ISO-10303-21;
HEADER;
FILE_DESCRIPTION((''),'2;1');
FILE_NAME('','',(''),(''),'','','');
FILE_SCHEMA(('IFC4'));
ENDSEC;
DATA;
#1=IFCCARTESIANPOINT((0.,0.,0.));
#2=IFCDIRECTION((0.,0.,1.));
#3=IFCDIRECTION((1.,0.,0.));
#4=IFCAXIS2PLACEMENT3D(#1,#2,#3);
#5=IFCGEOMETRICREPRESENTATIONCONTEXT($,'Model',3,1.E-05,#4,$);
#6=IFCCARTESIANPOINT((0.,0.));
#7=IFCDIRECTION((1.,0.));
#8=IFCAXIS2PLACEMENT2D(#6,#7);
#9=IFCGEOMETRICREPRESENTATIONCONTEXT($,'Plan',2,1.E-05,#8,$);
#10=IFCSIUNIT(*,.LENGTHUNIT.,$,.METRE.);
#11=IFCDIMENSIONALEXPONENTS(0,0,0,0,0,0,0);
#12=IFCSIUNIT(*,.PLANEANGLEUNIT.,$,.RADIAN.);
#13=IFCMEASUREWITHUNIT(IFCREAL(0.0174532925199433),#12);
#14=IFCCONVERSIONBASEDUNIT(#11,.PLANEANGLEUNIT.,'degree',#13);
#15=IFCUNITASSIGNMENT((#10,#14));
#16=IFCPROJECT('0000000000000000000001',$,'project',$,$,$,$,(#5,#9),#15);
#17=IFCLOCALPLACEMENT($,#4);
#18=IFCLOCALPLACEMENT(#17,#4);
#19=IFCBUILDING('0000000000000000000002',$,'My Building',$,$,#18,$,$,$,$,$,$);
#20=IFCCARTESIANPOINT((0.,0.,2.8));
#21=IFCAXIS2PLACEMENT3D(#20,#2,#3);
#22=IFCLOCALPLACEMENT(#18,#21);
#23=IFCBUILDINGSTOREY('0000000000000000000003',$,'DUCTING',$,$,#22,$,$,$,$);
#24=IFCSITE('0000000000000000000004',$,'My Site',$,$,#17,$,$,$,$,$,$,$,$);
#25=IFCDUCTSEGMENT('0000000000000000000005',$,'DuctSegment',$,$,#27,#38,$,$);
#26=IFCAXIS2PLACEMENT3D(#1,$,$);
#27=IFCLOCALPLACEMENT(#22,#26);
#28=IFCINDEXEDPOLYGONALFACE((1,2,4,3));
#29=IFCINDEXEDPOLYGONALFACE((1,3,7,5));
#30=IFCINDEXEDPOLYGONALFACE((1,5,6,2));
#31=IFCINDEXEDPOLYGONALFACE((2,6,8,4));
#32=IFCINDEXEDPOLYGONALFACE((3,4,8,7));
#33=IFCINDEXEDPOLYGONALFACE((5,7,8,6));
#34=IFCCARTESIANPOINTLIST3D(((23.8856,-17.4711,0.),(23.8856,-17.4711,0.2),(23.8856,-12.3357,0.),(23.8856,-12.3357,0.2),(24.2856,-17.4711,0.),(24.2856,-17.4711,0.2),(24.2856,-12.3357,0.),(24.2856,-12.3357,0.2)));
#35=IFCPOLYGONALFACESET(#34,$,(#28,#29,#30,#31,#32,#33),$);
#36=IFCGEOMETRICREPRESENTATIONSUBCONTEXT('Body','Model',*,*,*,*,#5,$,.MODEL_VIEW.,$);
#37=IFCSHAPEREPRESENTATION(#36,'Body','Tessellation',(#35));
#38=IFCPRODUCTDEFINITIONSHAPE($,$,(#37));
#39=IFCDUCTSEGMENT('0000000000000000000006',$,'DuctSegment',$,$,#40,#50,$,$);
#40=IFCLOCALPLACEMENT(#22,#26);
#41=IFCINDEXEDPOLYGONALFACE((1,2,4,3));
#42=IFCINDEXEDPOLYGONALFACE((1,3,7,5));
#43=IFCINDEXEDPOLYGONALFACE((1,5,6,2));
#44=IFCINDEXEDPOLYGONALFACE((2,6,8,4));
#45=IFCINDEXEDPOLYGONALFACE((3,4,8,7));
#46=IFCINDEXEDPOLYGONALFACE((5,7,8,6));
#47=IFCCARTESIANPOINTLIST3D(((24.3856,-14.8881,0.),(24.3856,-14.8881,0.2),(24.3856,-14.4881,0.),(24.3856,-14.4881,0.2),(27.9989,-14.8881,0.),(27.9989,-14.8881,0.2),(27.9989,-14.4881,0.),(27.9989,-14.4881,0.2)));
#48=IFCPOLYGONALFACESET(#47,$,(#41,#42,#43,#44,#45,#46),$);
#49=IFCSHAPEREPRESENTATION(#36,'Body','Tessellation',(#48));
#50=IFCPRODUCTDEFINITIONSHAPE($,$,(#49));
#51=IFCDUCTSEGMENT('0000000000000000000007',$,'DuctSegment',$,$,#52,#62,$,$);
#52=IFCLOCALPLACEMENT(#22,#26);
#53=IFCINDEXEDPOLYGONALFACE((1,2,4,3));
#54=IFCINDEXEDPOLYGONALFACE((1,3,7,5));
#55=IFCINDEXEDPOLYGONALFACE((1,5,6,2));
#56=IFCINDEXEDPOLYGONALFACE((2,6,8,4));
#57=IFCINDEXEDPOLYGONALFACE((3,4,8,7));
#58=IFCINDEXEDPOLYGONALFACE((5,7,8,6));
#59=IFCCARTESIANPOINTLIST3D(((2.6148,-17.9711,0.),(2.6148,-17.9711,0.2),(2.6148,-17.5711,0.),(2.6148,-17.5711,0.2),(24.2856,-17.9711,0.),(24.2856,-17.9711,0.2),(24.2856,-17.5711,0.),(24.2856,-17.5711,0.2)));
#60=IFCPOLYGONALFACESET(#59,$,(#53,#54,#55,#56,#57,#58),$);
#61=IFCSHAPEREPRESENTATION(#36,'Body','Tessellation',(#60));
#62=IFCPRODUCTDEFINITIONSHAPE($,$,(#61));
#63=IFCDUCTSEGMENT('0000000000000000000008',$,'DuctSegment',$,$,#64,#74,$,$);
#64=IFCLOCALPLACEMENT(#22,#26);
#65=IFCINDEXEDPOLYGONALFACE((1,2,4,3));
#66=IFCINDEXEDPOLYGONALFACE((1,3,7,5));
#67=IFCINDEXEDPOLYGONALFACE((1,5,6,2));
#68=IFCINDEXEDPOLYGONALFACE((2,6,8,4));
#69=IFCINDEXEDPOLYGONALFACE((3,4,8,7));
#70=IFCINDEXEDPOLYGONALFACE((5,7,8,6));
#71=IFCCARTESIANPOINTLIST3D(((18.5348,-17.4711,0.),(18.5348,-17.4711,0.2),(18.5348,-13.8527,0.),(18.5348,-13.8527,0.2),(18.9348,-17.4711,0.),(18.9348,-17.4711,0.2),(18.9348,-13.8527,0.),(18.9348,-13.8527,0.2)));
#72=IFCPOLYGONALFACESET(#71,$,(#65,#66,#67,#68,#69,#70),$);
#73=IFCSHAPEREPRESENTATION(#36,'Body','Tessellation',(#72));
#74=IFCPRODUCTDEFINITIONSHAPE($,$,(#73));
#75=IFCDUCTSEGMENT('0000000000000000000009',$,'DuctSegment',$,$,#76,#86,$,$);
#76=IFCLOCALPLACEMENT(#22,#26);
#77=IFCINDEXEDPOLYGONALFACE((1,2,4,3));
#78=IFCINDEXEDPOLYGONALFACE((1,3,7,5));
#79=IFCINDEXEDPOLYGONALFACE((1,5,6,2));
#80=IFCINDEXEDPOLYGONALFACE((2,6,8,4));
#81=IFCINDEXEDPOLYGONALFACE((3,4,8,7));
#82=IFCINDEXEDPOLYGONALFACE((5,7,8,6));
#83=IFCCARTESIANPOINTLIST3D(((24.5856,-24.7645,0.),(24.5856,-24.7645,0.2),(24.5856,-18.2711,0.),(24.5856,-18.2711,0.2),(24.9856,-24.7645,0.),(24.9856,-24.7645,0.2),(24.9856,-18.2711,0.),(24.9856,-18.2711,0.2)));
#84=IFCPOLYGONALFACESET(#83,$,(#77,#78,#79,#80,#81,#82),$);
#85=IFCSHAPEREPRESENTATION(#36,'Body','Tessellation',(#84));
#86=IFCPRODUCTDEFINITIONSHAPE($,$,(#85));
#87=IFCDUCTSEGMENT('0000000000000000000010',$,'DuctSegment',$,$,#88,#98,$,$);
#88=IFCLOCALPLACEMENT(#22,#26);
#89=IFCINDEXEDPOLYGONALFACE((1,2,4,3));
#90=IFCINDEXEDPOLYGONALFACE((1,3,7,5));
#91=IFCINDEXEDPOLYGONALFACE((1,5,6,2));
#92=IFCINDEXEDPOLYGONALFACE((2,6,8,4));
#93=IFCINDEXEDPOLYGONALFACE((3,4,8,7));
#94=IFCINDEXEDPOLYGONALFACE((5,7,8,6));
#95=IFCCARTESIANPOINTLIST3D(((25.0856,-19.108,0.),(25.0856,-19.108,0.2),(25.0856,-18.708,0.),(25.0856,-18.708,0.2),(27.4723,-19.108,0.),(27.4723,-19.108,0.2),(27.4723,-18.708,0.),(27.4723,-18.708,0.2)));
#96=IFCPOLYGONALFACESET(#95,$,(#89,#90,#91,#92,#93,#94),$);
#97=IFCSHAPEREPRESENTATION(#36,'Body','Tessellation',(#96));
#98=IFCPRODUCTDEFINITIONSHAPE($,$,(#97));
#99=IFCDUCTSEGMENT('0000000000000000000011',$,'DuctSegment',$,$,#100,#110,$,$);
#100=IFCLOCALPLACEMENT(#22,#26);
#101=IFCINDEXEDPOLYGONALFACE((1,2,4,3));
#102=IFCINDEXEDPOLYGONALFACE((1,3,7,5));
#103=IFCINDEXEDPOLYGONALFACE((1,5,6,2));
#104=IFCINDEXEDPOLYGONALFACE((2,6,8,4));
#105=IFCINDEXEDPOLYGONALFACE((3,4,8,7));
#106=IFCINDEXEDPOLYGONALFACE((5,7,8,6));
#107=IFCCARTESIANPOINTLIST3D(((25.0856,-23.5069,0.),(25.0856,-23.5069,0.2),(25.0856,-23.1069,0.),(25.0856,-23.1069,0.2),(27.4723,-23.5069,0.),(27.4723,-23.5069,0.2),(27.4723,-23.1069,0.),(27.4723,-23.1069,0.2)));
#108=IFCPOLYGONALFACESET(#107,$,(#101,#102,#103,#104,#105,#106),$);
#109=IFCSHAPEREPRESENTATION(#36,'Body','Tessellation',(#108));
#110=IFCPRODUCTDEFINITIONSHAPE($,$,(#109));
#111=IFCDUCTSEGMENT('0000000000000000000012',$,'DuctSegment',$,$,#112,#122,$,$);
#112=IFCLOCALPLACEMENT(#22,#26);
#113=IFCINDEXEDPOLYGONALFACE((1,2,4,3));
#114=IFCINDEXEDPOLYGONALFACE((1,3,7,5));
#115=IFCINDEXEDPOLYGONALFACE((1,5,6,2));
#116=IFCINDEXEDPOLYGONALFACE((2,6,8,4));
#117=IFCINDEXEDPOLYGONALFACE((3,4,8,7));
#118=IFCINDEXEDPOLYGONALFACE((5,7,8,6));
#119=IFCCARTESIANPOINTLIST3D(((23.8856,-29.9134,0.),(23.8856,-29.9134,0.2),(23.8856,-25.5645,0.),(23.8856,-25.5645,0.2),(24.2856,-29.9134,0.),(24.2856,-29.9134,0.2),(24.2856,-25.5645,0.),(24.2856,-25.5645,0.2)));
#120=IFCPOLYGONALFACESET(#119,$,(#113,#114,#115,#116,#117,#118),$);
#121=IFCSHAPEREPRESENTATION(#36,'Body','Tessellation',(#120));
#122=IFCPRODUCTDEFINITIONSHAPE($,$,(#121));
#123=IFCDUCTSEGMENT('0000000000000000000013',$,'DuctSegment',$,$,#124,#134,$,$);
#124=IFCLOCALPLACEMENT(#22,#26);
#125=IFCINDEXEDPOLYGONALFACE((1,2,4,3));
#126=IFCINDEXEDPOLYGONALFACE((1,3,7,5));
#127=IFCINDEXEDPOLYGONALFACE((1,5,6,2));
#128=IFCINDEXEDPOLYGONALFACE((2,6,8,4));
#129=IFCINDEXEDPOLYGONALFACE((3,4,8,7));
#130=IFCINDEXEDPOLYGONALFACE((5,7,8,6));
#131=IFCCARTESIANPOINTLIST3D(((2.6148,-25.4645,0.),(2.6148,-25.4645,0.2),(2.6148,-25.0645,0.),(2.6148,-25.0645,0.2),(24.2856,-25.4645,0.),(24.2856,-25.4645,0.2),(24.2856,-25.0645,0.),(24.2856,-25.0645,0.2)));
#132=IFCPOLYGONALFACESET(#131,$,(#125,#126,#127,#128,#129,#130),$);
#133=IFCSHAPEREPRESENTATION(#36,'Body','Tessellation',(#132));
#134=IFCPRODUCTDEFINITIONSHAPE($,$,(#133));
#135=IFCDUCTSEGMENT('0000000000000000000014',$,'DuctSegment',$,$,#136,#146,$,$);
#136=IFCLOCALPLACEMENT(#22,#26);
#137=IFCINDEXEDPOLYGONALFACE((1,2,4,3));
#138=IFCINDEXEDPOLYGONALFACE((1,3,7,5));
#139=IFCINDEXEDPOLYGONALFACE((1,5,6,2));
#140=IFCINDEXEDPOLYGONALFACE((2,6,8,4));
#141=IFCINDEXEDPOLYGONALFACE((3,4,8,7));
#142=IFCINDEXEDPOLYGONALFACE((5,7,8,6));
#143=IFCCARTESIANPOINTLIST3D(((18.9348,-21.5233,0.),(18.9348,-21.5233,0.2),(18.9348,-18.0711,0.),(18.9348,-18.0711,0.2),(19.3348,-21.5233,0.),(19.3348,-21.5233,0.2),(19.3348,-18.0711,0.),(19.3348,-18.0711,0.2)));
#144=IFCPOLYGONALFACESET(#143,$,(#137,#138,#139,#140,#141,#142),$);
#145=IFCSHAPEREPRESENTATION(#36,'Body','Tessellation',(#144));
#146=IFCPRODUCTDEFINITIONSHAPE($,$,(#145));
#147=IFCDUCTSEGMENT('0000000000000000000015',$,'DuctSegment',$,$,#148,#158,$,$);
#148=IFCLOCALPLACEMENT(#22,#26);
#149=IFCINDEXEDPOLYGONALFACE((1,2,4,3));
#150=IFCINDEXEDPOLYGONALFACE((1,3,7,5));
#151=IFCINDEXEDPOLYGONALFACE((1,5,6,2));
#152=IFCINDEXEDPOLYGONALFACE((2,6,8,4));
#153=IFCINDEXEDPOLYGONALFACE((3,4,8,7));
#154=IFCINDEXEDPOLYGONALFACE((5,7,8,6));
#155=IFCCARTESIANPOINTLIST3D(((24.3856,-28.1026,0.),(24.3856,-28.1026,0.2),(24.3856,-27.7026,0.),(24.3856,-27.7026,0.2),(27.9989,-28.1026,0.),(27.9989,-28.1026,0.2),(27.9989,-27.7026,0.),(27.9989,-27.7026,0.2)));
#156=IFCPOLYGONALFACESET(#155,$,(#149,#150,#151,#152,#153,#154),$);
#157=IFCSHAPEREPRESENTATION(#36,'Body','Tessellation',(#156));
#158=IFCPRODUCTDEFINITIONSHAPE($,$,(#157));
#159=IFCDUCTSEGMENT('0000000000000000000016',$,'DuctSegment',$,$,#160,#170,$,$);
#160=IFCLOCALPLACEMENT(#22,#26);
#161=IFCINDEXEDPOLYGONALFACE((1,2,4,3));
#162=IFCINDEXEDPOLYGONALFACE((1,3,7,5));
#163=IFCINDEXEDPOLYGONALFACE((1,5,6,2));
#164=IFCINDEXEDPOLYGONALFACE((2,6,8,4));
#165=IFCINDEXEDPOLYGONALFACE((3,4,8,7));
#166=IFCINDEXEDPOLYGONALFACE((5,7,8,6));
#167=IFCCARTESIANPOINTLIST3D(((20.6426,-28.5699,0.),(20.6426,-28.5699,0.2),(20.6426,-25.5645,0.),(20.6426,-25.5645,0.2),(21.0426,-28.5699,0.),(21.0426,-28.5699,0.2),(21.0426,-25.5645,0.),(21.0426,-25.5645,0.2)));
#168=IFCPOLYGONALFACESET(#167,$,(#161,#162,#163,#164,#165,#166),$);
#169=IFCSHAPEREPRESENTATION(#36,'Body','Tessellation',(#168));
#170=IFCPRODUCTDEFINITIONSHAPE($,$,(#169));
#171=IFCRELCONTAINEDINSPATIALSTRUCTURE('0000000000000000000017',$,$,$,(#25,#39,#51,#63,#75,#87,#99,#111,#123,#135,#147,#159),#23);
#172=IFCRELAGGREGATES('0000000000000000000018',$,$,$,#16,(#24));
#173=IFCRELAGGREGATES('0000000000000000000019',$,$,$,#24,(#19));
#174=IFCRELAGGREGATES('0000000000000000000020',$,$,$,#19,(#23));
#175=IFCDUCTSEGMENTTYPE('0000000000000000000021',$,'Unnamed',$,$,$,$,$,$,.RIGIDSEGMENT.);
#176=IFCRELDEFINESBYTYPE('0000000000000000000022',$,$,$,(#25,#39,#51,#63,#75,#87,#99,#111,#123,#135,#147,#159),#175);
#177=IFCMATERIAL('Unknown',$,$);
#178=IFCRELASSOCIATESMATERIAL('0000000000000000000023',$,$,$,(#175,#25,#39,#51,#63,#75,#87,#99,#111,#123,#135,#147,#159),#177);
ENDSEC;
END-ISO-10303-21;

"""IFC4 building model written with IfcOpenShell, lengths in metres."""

from ifc_helpers import new_model, entity, si_unit, converted_unit, frame, origin_with_axes, origin_2d_with_axis, place, context, subcontext, project, spatial, rectangle, extrude, material, material_profile, profile_set, profile_usage, type_object, element, save


model = new_model("IFC4")

# Units and contexts
model_context = context("Model", 3, precision=1e-05, world=origin_with_axes())
plan_context = context("Plan", 2, precision=1e-05, world=origin_2d_with_axis())
body_context = subcontext(model_context, "Body", "Model", "MODEL_VIEW")
ifc_project = project(units=[si_unit("LENGTHUNIT", "METRE"), converted_unit("PLANEANGLEUNIT", "degree", entity("IfcReal", 0.0174532925199433), si_unit("PLANEANGLEUNIT", "RADIAN"), dimensions=[0, 0, 0, 0, 0, 0, 0])], contexts=[model_context, plan_context])

# Site, building, storey
site_placement = place(None, origin_with_axes())
site = spatial("IfcSite", under=ifc_project, at=site_placement, Name="My Site")
building_placement = place(site_placement, origin_with_axes())
building = spatial("IfcBuilding", under=site, at=building_placement, Name="My Building")
storey_placement = place(building_placement, frame((0.0, 0.0, 2.8), z_axis=(0.0, 0.0, 1.0), x_axis=(1.0, 0.0, 0.0)))
storey = spatial("IfcBuildingStorey", under=building, at=storey_placement, Name="DUCTING")

# Duct segments
ifc_material = material(Name="Unknown")
ifc_material_profile_1 = material_profile(ifc_material, rectangle(XDim=0.4, YDim=0.2))
ifc_profile_set_1 = profile_set([ifc_material_profile_1])
ifc_profile_usage_1 = profile_usage(ifc_profile_set_1, cardinal=5)
duct_segment_type = type_object("IfcDuctSegmentType", Name="Unnamed", PredefinedType="RIGIDSEGMENT", material=ifc_profile_set_1)
duct_segment_1_placement = place(storey_placement, frame((24.0856, -17.4711, 0.1), z_axis=(0.0, 1.0, 0.0), x_axis=(-1.0, 0.0, 0.0)))
element("IfcDuctSegment", 1, at=duct_segment_1_placement, inside=storey, type_object=duct_segment_type, material=ifc_profile_usage_1, Name="DuctSegment", context=body_context, shape_type="SweptSolid", body=[
    extrude(rectangle(XDim=0.4, YDim=0.2), origin_with_axes(), (0.0, 0.0, 1.0), 5.1353),
])
ifc_profile_usage_2 = profile_usage(ifc_profile_set_1, cardinal=5)
duct_segment_2_placement = place(storey_placement, frame((24.3856, -14.6881, 0.1), z_axis=(1.0, 0.0, 0.0), x_axis=(0.0, 1.0, 0.0)))
element("IfcDuctSegment", 2, at=duct_segment_2_placement, inside=storey, type_object=duct_segment_type, material=ifc_profile_usage_2, Name="DuctSegment", context=body_context, shape_type="SweptSolid", body=[
    extrude(rectangle(XDim=0.4, YDim=0.2), origin_with_axes(), (0.0, 0.0, 1.0), 3.6133),
])
ifc_profile_usage_3 = profile_usage(ifc_profile_set_1, cardinal=5)
duct_segment_3_placement = place(storey_placement, frame((24.2856, -17.7711, 0.1), z_axis=(-1.0, 0.0, 0.0), x_axis=(0.0, -1.0, 0.0)))
element("IfcDuctSegment", 3, at=duct_segment_3_placement, inside=storey, type_object=duct_segment_type, material=ifc_profile_usage_3, Name="DuctSegment", context=body_context, shape_type="SweptSolid", body=[
    extrude(rectangle(XDim=0.4, YDim=0.2), origin_with_axes(), (0.0, 0.0, 1.0), 21.6708),
])
ifc_profile_usage_4 = profile_usage(ifc_profile_set_1, cardinal=5)
duct_segment_4_placement = place(storey_placement, frame((18.7348, -17.4711, 0.1), z_axis=(0.0, 1.0, 0.0), x_axis=(-1.0, 0.0, 0.0)))
element("IfcDuctSegment", 4, at=duct_segment_4_placement, inside=storey, type_object=duct_segment_type, material=ifc_profile_usage_4, Name="DuctSegment", context=body_context, shape_type="SweptSolid", body=[
    extrude(rectangle(XDim=0.4, YDim=0.2), origin_with_axes(), (0.0, 0.0, 1.0), 3.6184),
])
ifc_profile_usage_5 = profile_usage(ifc_profile_set_1, cardinal=5)
duct_segment_5_placement = place(storey_placement, frame((24.7856, -18.2711, 0.1), z_axis=(0.0, -1.0, 0.0), x_axis=(1.0, 0.0, 0.0)))
element("IfcDuctSegment", 5, at=duct_segment_5_placement, inside=storey, type_object=duct_segment_type, material=ifc_profile_usage_5, Name="DuctSegment", context=body_context, shape_type="SweptSolid", body=[
    extrude(rectangle(XDim=0.4, YDim=0.2), origin_with_axes(), (0.0, 0.0, 1.0), 6.4934),
])
ifc_profile_usage_6 = profile_usage(ifc_profile_set_1, cardinal=5)
duct_segment_6_placement = place(storey_placement, frame((25.0856, -18.908, 0.1), z_axis=(1.0, 0.0, 0.0), x_axis=(0.0, 1.0, 0.0)))
element("IfcDuctSegment", 6, at=duct_segment_6_placement, inside=storey, type_object=duct_segment_type, material=ifc_profile_usage_6, Name="DuctSegment", context=body_context, shape_type="SweptSolid", body=[
    extrude(rectangle(XDim=0.4, YDim=0.2), origin_with_axes(), (0.0, 0.0, 1.0), 2.3868),
])
ifc_profile_usage_7 = profile_usage(ifc_profile_set_1, cardinal=5)
duct_segment_7_placement = place(storey_placement, frame((25.0856, -23.3069, 0.1), z_axis=(1.0, 0.0, 0.0), x_axis=(0.0, 1.0, 0.0)))
element("IfcDuctSegment", 7, at=duct_segment_7_placement, inside=storey, type_object=duct_segment_type, material=ifc_profile_usage_7, Name="DuctSegment", context=body_context, shape_type="SweptSolid", body=[
    extrude(rectangle(XDim=0.4, YDim=0.2), origin_with_axes(), (0.0, 0.0, 1.0), 2.3868),
])
ifc_profile_usage_8 = profile_usage(ifc_profile_set_1, cardinal=5)
duct_segment_8_placement = place(storey_placement, frame((24.0856, -25.5645, 0.1), z_axis=(0.0, -1.0, 0.0), x_axis=(1.0, 0.0, 0.0)))
element("IfcDuctSegment", 8, at=duct_segment_8_placement, inside=storey, type_object=duct_segment_type, material=ifc_profile_usage_8, Name="DuctSegment", context=body_context, shape_type="SweptSolid", body=[
    extrude(rectangle(XDim=0.4, YDim=0.2), origin_with_axes(), (0.0, 0.0, 1.0), 4.3489),
])
ifc_profile_usage_9 = profile_usage(ifc_profile_set_1, cardinal=5)
duct_segment_9_placement = place(storey_placement, frame((24.2856, -25.2645, 0.1), z_axis=(-1.0, 0.0, 0.0), x_axis=(0.0, -1.0, 0.0)))
element("IfcDuctSegment", 9, at=duct_segment_9_placement, inside=storey, type_object=duct_segment_type, material=ifc_profile_usage_9, Name="DuctSegment", context=body_context, shape_type="SweptSolid", body=[
    extrude(rectangle(XDim=0.4, YDim=0.2), origin_with_axes(), (0.0, 0.0, 1.0), 21.6708),
])
ifc_profile_usage_10 = profile_usage(ifc_profile_set_1, cardinal=5)
duct_segment_10_placement = place(storey_placement, frame((19.1348, -18.0711, 0.1), z_axis=(0.0, -1.0, 0.0), x_axis=(1.0, 0.0, 0.0)))
element("IfcDuctSegment", 10, at=duct_segment_10_placement, inside=storey, type_object=duct_segment_type, material=ifc_profile_usage_10, Name="DuctSegment", context=body_context, shape_type="SweptSolid", body=[
    extrude(rectangle(XDim=0.4, YDim=0.2), origin_with_axes(), (0.0, 0.0, 1.0), 3.4523),
])
ifc_profile_usage_11 = profile_usage(ifc_profile_set_1, cardinal=5)
duct_segment_11_placement = place(storey_placement, frame((24.3856, -27.9026, 0.1), z_axis=(1.0, 0.0, 0.0), x_axis=(0.0, 1.0, 0.0)))
element("IfcDuctSegment", 11, at=duct_segment_11_placement, inside=storey, type_object=duct_segment_type, material=ifc_profile_usage_11, Name="DuctSegment", context=body_context, shape_type="SweptSolid", body=[
    extrude(rectangle(XDim=0.4, YDim=0.2), origin_with_axes(), (0.0, 0.0, 1.0), 3.6133),
])
ifc_profile_usage_12 = profile_usage(ifc_profile_set_1, cardinal=5)
duct_segment_12_placement = place(storey_placement, frame((20.8426, -28.5699, 0.1), z_axis=(0.0, 1.0, 0.0), x_axis=(-1.0, 0.0, 0.0)))
element("IfcDuctSegment", 12, at=duct_segment_12_placement, inside=storey, type_object=duct_segment_type, material=ifc_profile_usage_12, Name="DuctSegment", context=body_context, shape_type="SweptSolid", body=[
    extrude(rectangle(XDim=0.4, YDim=0.2), origin_with_axes(), (0.0, 0.0, 1.0), 3.0055),
])

save(model, "model.ifc")
